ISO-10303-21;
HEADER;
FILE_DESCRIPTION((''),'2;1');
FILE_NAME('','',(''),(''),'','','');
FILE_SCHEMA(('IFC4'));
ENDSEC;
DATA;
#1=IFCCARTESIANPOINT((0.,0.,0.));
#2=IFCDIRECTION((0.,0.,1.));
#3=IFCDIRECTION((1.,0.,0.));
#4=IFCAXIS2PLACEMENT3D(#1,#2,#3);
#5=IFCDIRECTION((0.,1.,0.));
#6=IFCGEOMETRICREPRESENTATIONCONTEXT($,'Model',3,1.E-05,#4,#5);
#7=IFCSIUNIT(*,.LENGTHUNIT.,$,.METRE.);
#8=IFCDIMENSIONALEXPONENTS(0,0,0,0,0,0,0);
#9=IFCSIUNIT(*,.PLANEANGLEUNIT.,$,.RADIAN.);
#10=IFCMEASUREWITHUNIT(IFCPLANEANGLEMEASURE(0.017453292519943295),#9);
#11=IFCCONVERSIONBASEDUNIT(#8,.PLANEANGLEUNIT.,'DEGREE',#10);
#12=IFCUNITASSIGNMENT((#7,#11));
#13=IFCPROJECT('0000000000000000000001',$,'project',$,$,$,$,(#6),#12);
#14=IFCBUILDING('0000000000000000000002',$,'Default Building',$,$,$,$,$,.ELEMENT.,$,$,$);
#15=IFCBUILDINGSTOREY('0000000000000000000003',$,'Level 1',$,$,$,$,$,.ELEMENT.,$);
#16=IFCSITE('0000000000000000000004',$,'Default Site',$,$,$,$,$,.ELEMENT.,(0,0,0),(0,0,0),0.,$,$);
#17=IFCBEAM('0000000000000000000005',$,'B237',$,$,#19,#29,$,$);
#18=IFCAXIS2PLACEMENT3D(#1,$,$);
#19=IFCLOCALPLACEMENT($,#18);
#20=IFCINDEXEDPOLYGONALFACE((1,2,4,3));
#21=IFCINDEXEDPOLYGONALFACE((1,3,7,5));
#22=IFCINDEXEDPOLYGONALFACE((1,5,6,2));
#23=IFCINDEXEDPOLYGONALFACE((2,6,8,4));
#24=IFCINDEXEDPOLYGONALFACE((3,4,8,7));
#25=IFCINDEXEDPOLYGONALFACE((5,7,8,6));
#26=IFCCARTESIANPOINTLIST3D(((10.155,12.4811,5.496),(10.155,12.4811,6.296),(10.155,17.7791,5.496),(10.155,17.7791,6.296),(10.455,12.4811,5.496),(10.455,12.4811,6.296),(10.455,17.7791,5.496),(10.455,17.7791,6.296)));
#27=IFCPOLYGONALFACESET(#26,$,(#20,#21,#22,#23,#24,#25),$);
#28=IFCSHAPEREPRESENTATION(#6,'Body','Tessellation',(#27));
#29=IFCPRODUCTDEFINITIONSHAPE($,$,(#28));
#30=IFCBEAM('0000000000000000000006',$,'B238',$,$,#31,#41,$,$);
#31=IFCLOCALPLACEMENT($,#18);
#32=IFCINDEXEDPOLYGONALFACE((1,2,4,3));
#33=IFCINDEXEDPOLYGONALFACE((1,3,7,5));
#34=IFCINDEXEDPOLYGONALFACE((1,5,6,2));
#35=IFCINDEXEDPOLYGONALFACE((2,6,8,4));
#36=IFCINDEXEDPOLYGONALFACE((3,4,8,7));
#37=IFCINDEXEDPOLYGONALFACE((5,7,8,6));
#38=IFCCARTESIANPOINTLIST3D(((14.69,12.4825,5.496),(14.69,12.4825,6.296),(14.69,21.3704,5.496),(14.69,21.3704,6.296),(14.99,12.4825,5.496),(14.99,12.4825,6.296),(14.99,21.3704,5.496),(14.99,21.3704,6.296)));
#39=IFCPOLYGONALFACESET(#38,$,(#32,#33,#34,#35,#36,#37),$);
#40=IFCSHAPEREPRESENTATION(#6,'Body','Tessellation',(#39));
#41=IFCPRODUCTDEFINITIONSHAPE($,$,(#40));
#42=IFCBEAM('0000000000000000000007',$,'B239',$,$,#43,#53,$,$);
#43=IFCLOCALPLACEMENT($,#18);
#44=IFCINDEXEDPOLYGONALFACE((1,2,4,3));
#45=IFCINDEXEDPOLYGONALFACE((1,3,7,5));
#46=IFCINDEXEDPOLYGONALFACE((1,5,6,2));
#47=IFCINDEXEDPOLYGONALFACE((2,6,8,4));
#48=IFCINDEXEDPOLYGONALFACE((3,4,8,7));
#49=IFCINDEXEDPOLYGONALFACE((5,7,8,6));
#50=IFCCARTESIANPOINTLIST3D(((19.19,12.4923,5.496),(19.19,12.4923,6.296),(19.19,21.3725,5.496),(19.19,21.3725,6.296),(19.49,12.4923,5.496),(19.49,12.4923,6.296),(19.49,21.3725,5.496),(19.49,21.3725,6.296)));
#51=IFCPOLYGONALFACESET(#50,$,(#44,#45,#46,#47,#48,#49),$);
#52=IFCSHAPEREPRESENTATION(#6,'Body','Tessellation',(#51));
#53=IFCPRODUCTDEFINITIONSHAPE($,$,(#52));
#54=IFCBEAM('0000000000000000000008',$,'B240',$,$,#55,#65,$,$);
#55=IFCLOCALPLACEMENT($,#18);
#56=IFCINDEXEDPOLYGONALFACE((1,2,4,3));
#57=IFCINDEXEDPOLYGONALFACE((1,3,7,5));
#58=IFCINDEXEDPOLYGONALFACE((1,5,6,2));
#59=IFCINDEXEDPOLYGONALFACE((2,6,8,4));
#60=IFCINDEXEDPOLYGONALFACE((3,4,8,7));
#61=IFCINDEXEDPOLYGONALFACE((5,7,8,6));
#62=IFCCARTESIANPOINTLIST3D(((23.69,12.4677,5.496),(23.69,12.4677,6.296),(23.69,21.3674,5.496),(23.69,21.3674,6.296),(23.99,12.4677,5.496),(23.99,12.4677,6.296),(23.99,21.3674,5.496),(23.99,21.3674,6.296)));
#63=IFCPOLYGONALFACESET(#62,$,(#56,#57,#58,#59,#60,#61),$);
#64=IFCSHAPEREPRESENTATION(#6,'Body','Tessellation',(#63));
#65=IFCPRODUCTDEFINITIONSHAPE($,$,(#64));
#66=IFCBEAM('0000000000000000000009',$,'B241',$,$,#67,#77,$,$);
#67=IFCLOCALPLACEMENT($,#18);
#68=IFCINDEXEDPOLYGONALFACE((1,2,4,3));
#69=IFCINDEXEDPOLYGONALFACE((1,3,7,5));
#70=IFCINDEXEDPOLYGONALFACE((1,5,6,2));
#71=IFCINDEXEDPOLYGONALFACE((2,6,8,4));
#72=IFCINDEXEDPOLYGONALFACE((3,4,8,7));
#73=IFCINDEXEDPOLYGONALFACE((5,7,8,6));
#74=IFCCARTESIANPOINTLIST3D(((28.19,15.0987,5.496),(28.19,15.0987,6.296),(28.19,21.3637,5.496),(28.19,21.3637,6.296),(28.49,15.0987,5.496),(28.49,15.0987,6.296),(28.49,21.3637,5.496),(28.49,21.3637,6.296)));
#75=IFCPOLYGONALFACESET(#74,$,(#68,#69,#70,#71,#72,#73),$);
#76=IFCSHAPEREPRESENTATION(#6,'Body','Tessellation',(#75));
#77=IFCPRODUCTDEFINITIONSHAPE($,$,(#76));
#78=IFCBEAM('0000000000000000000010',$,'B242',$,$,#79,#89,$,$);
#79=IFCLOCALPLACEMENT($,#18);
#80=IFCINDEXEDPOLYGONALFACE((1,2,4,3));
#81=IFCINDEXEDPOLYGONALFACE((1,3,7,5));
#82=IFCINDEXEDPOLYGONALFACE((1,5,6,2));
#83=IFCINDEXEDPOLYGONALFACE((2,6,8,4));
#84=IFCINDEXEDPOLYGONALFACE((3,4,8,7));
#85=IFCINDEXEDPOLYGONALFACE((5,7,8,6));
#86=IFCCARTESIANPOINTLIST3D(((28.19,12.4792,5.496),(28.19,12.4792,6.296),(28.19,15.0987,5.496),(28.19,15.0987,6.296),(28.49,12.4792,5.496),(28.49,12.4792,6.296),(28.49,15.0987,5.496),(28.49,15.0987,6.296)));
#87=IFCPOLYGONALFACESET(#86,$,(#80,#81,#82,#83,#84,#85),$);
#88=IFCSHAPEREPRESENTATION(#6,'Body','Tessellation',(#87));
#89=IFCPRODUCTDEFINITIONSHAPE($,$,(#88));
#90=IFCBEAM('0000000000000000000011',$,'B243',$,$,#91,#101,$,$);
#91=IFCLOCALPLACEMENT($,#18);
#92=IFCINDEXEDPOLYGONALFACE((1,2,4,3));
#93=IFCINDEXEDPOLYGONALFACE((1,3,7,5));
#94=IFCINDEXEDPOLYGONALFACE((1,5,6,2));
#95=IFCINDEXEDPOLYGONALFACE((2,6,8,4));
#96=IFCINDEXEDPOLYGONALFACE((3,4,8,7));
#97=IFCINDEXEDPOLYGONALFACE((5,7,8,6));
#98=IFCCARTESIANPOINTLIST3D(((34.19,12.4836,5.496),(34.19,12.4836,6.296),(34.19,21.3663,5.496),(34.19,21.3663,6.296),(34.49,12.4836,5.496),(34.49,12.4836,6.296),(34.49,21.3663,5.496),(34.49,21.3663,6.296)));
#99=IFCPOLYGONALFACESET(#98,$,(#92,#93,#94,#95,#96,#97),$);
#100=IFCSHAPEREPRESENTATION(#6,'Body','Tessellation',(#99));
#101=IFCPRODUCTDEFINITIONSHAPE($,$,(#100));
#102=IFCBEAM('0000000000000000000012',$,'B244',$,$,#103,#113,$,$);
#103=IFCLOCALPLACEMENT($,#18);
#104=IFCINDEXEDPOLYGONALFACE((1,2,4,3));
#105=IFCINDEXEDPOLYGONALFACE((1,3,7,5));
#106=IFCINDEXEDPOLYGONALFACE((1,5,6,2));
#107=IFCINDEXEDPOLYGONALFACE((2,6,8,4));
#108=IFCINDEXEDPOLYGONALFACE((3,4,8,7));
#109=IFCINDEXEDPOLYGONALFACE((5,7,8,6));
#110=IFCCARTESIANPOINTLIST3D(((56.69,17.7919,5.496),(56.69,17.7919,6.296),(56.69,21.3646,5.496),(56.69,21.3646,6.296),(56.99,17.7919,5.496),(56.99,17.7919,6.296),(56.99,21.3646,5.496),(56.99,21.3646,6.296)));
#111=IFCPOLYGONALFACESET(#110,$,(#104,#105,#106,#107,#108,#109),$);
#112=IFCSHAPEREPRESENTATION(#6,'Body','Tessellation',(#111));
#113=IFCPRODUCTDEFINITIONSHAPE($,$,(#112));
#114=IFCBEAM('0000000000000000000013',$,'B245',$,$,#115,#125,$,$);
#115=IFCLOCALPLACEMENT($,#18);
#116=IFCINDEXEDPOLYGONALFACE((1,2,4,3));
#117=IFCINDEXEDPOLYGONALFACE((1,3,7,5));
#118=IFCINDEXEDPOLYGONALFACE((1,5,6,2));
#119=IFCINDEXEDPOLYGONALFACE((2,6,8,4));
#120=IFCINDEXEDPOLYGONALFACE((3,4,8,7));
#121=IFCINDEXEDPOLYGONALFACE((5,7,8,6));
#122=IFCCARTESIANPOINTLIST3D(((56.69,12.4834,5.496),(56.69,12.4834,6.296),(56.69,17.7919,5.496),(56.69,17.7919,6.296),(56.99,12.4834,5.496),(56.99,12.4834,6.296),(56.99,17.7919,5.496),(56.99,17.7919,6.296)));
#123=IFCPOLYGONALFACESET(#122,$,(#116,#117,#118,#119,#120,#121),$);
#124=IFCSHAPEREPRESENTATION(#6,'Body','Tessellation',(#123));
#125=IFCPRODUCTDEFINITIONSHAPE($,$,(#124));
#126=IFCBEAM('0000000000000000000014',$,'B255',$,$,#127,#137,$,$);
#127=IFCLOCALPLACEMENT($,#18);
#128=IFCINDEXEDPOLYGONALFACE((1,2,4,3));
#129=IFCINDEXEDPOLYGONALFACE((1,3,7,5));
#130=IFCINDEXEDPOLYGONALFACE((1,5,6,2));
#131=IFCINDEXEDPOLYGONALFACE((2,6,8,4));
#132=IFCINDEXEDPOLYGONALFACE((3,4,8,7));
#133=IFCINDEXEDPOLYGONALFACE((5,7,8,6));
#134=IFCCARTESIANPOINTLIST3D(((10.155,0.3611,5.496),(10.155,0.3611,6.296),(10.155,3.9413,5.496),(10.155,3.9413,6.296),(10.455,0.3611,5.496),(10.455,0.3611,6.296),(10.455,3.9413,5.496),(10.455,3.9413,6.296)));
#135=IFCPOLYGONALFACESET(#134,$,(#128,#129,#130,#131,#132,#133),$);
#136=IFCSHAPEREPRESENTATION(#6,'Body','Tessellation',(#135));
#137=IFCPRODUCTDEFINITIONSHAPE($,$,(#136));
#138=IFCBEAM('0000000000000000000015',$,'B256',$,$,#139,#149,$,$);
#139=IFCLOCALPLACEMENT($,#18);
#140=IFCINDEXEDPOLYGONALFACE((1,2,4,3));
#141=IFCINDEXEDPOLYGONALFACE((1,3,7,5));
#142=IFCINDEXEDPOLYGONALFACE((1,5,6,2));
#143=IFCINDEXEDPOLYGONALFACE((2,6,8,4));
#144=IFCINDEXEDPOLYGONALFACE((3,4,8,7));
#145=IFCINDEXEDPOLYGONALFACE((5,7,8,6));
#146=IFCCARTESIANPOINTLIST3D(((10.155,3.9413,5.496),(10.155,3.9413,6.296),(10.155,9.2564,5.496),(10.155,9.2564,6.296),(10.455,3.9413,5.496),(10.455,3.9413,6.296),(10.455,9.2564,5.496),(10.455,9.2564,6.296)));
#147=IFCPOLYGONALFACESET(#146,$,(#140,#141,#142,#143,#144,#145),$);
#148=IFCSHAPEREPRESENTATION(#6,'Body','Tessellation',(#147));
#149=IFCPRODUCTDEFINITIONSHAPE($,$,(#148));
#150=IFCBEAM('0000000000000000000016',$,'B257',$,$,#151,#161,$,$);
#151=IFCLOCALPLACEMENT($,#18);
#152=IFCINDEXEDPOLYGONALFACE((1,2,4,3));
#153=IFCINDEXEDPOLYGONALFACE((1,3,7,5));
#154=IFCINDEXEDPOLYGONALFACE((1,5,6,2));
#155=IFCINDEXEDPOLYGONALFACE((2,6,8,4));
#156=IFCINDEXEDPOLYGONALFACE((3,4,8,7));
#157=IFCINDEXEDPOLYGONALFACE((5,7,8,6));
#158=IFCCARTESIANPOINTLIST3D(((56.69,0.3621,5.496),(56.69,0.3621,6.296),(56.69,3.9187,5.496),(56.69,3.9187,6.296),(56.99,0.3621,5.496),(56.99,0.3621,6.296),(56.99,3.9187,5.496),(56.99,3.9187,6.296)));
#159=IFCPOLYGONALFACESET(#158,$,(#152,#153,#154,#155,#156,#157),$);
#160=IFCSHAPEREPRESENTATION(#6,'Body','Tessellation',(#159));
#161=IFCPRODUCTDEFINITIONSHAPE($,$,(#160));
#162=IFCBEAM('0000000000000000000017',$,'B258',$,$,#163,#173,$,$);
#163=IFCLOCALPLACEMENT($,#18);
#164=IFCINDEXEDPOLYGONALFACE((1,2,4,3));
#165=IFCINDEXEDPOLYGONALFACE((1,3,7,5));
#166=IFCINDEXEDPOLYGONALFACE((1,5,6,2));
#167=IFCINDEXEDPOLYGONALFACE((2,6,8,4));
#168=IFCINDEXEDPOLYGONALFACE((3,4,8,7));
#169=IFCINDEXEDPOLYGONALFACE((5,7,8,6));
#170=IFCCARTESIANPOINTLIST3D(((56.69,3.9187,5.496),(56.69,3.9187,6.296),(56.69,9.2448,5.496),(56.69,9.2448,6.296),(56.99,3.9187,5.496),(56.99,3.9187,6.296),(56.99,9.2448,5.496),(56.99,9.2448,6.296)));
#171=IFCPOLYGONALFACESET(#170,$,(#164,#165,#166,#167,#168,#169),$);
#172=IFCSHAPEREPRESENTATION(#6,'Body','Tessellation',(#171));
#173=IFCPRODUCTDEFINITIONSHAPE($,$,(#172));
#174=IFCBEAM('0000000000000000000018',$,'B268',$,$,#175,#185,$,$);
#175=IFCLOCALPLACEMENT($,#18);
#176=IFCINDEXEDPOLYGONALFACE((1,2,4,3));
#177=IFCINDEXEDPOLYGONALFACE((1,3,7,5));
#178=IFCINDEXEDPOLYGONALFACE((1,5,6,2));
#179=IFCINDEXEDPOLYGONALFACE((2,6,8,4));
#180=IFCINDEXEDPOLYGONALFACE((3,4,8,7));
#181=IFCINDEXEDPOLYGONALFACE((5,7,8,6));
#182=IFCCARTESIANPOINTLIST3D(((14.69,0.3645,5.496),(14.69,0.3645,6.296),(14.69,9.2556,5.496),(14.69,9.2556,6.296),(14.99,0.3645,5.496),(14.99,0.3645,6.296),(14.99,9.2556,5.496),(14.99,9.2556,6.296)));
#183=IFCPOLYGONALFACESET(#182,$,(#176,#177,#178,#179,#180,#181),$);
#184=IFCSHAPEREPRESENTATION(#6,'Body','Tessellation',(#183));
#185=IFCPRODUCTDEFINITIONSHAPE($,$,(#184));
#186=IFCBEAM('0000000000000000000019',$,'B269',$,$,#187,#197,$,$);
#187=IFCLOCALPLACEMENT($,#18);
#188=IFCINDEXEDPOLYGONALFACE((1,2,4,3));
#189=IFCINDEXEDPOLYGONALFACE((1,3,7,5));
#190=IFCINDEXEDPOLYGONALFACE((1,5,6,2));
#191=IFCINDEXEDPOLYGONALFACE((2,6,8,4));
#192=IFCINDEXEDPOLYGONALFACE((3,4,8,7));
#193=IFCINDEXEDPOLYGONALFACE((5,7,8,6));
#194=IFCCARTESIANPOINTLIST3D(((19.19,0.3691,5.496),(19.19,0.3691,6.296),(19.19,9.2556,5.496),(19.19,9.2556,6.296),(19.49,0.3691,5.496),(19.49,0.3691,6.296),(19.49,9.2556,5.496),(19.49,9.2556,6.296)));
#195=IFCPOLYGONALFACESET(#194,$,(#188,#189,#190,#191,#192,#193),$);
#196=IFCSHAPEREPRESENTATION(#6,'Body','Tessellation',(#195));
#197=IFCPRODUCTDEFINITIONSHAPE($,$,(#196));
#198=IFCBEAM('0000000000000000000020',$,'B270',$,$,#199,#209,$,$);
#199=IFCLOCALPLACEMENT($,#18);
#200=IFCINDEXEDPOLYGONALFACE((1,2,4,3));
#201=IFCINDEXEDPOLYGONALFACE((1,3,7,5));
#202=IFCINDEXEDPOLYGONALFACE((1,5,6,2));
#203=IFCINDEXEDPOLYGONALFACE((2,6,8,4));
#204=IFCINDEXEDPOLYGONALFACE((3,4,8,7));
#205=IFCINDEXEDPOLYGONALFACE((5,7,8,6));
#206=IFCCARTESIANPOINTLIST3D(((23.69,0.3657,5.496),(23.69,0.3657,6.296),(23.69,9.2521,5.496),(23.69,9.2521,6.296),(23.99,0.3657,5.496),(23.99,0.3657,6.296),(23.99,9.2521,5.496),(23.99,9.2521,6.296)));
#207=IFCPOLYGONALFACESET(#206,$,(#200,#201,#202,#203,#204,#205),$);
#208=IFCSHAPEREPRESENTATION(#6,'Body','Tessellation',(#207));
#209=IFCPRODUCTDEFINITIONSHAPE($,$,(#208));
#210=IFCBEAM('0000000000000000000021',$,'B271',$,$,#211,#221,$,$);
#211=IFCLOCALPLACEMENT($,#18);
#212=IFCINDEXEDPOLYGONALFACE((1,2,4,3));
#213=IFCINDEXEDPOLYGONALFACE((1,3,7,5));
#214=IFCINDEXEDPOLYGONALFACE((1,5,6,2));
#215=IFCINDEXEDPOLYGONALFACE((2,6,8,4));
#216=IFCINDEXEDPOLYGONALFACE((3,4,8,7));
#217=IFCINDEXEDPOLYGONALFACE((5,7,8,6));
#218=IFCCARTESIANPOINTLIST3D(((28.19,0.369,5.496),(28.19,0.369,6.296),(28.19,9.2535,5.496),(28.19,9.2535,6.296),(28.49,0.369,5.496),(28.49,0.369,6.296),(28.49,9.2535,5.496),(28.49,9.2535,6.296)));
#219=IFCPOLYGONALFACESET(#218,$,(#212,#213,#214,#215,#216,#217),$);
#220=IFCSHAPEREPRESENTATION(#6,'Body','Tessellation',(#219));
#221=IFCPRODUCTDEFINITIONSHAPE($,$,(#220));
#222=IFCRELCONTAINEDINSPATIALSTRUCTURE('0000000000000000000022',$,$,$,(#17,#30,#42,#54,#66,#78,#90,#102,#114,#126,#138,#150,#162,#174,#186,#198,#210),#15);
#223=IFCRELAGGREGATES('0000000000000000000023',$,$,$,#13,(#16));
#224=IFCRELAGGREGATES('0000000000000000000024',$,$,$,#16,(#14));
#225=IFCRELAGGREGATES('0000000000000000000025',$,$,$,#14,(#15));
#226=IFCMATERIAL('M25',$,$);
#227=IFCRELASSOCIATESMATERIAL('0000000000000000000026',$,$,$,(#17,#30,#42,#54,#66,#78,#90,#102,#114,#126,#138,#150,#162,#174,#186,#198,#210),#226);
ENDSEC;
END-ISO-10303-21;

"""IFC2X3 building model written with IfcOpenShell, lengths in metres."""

from ifc_helpers import new_model, entity, si_unit, converted_unit, direction, frame, frame_2d, origin_with_axes, place, context, project, spatial, rectangle, extrude, material, element, save


model = new_model("IFC2X3")

# Units and contexts
model_context = context("Model", 3, precision=1e-05, world=origin_with_axes(), true_north=direction((0.0, 1.0, 0.0)))
ifc_project = project(units=[si_unit("LENGTHUNIT", "METRE"), converted_unit("PLANEANGLEUNIT", "DEGREE", entity("IfcPlaneAngleMeasure", 0.017453292519943295), si_unit("PLANEANGLEUNIT", "RADIAN"), dimensions=[0, 0, 0, 0, 0, 0, 0])], contexts=[model_context])

# Site, building, storey
site = spatial("IfcSite", under=ifc_project, Name="Default Site", CompositionType="ELEMENT", RefLatitude=(0, 0, 0), RefLongitude=(0, 0, 0), RefElevation=0.0)
building = spatial("IfcBuilding", under=site, Name="Default Building", CompositionType="ELEMENT")
storey = spatial("IfcBuildingStorey", under=building, Name="Level 1", CompositionType="ELEMENT")

# Beams
ifc_material = material(Name="M25")
placement = place(None, origin_with_axes())
element("IfcBeam", 1, at=placement, inside=storey, material=ifc_material, Name="B237", context=model_context, shape_type="SweptSolid", body=[
    extrude(rectangle(XDim=0.3, YDim=0.8, at=frame_2d((0.0, 0.0), x_axis=(0.0, 1.0, 0.0))), frame((10.305, 17.7791, 5.896), z_axis=(0.0, -1.0, 0.0), x_axis=(0.0, 0.0, -1.0)), (0.0, 0.0, 1.0), 5.298),
])
element("IfcBeam", 2, at=placement, inside=storey, material=ifc_material, Name="B238", context=model_context, shape_type="SweptSolid", body=[
    extrude(rectangle(XDim=0.3, YDim=0.8, at=frame_2d((0.0, 0.0), x_axis=(0.0, 1.0, 0.0))), frame((14.84, 21.3704, 5.896), z_axis=(0.0, -1.0, 0.0), x_axis=(0.0, 0.0, -1.0)), (0.0, 0.0, 1.0), 8.8879),
])
element("IfcBeam", 3, at=placement, inside=storey, material=ifc_material, Name="B239", context=model_context, shape_type="SweptSolid", body=[
    extrude(rectangle(XDim=0.3, YDim=0.8, at=frame_2d((0.0, 0.0), x_axis=(0.0, 1.0, 0.0))), frame((19.34, 21.3725, 5.896), z_axis=(0.0, -1.0, 0.0), x_axis=(0.0, 0.0, -1.0)), (0.0, 0.0, 1.0), 8.8802),
])
element("IfcBeam", 4, at=placement, inside=storey, material=ifc_material, Name="B240", context=model_context, shape_type="SweptSolid", body=[
    extrude(rectangle(XDim=0.3, YDim=0.8, at=frame_2d((0.0, 0.0), x_axis=(0.0, 1.0, 0.0))), frame((23.84, 21.3674, 5.896), z_axis=(0.0, -1.0, 0.0), x_axis=(0.0, 0.0, -1.0)), (0.0, 0.0, 1.0), 8.8997),
])
element("IfcBeam", 5, at=placement, inside=storey, material=ifc_material, Name="B241", context=model_context, shape_type="SweptSolid", body=[
    extrude(rectangle(XDim=0.3, YDim=0.8, at=frame_2d((0.0, 0.0), x_axis=(0.0, 1.0, 0.0))), frame((28.34, 21.3637, 5.896), z_axis=(0.0, -1.0, 0.0), x_axis=(0.0, 0.0, -1.0)), (0.0, 0.0, 1.0), 6.265),
])
element("IfcBeam", 6, at=placement, inside=storey, material=ifc_material, Name="B242", context=model_context, shape_type="SweptSolid", body=[
    extrude(rectangle(XDim=0.3, YDim=0.8, at=frame_2d((0.0, 0.0), x_axis=(0.0, 1.0, 0.0))), frame((28.34, 15.0987, 5.896), z_axis=(0.0, -1.0, 0.0), x_axis=(0.0, 0.0, -1.0)), (0.0, 0.0, 1.0), 2.6195),
])
element("IfcBeam", 7, at=placement, inside=storey, material=ifc_material, Name="B243", context=model_context, shape_type="SweptSolid", body=[
    extrude(rectangle(XDim=0.3, YDim=0.8, at=frame_2d((0.0, 0.0), x_axis=(0.0, 1.0, 0.0))), frame((34.34, 12.4836, 5.896), z_axis=(0.0, 1.0, 0.0), x_axis=(0.0, 0.0, -1.0)), (0.0, 0.0, 1.0), 8.8827),
])
element("IfcBeam", 8, at=placement, inside=storey, material=ifc_material, Name="B244", context=model_context, shape_type="SweptSolid", body=[
    extrude(rectangle(XDim=0.3, YDim=0.8, at=frame_2d((0.0, 0.0), x_axis=(0.0, 1.0, 0.0))), frame((56.84, 17.7919, 5.896), z_axis=(0.0, 1.0, 0.0), x_axis=(0.0, 0.0, -1.0)), (0.0, 0.0, 1.0), 3.5727),
])
element("IfcBeam", 9, at=placement, inside=storey, material=ifc_material, Name="B245", context=model_context, shape_type="SweptSolid", body=[
    extrude(rectangle(XDim=0.3, YDim=0.8, at=frame_2d((0.0, 0.0), x_axis=(0.0, 1.0, 0.0))), frame((56.84, 12.4834, 5.896), z_axis=(0.0, 1.0, 0.0), x_axis=(0.0, 0.0, -1.0)), (0.0, 0.0, 1.0), 5.3085),
])
element("IfcBeam", 10, at=placement, inside=storey, material=ifc_material, Name="B255", context=model_context, shape_type="SweptSolid", body=[
    extrude(rectangle(XDim=0.3, YDim=0.8, at=frame_2d((0.0, 0.0), x_axis=(0.0, 1.0, 0.0))), frame((10.305, 3.9413, 5.896), z_axis=(0.0, -1.0, 0.0), x_axis=(0.0, 0.0, -1.0)), (0.0, 0.0, 1.0), 3.5802),
])
element("IfcBeam", 11, at=placement, inside=storey, material=ifc_material, Name="B256", context=model_context, shape_type="SweptSolid", body=[
    extrude(rectangle(XDim=0.3, YDim=0.8, at=frame_2d((0.0, 0.0), x_axis=(0.0, 1.0, 0.0))), frame((10.305, 3.9413, 5.896), z_axis=(0.0, 1.0, 0.0), x_axis=(0.0, 0.0, -1.0)), (0.0, 0.0, 1.0), 5.3151),
])
element("IfcBeam", 12, at=placement, inside=storey, material=ifc_material, Name="B257", context=model_context, shape_type="SweptSolid", body=[
    extrude(rectangle(XDim=0.3, YDim=0.8, at=frame_2d((0.0, 0.0), x_axis=(0.0, 1.0, 0.0))), frame((56.84, 0.3621, 5.896), z_axis=(0.0, 1.0, 0.0), x_axis=(0.0, 0.0, -1.0)), (0.0, 0.0, 1.0), 3.5566),
])
element("IfcBeam", 13, at=placement, inside=storey, material=ifc_material, Name="B258", context=model_context, shape_type="SweptSolid", body=[
    extrude(rectangle(XDim=0.3, YDim=0.8, at=frame_2d((0.0, 0.0), x_axis=(0.0, 1.0, 0.0))), frame((56.84, 3.9187, 5.896), z_axis=(0.0, 1.0, 0.0), x_axis=(0.0, 0.0, -1.0)), (0.0, 0.0, 1.0), 5.3261),
])
element("IfcBeam", 14, at=placement, inside=storey, material=ifc_material, Name="B268", context=model_context, shape_type="SweptSolid", body=[
    extrude(rectangle(XDim=0.3, YDim=0.8, at=frame_2d((0.0, 0.0), x_axis=(0.0, 1.0, 0.0))), frame((14.84, 0.3645, 5.896), z_axis=(0.0, 1.0, 0.0), x_axis=(0.0, 0.0, -1.0)), (0.0, 0.0, 1.0), 8.891),
])
element("IfcBeam", 15, at=placement, inside=storey, material=ifc_material, Name="B269", context=model_context, shape_type="SweptSolid", body=[
    extrude(rectangle(XDim=0.3, YDim=0.8, at=frame_2d((0.0, 0.0), x_axis=(0.0, 1.0, 0.0))), frame((19.34, 0.3691, 5.896), z_axis=(0.0, 1.0, 0.0), x_axis=(0.0, 0.0, -1.0)), (0.0, 0.0, 1.0), 8.8865),
])
element("IfcBeam", 16, at=placement, inside=storey, material=ifc_material, Name="B270", context=model_context, shape_type="SweptSolid", body=[
    extrude(rectangle(XDim=0.3, YDim=0.8, at=frame_2d((0.0, 0.0), x_axis=(0.0, 1.0, 0.0))), frame((23.84, 0.3657, 5.896), z_axis=(0.0, 1.0, 0.0), x_axis=(0.0, 0.0, -1.0)), (0.0, 0.0, 1.0), 8.8864),
])
element("IfcBeam", 17, at=placement, inside=storey, material=ifc_material, Name="B271", context=model_context, shape_type="SweptSolid", body=[
    extrude(rectangle(XDim=0.3, YDim=0.8, at=frame_2d((0.0, 0.0), x_axis=(0.0, 1.0, 0.0))), frame((28.34, 0.369, 5.896), z_axis=(0.0, 1.0, 0.0), x_axis=(0.0, 0.0, -1.0)), (0.0, 0.0, 1.0), 8.8845),
])

save(model, "model.ifc")
